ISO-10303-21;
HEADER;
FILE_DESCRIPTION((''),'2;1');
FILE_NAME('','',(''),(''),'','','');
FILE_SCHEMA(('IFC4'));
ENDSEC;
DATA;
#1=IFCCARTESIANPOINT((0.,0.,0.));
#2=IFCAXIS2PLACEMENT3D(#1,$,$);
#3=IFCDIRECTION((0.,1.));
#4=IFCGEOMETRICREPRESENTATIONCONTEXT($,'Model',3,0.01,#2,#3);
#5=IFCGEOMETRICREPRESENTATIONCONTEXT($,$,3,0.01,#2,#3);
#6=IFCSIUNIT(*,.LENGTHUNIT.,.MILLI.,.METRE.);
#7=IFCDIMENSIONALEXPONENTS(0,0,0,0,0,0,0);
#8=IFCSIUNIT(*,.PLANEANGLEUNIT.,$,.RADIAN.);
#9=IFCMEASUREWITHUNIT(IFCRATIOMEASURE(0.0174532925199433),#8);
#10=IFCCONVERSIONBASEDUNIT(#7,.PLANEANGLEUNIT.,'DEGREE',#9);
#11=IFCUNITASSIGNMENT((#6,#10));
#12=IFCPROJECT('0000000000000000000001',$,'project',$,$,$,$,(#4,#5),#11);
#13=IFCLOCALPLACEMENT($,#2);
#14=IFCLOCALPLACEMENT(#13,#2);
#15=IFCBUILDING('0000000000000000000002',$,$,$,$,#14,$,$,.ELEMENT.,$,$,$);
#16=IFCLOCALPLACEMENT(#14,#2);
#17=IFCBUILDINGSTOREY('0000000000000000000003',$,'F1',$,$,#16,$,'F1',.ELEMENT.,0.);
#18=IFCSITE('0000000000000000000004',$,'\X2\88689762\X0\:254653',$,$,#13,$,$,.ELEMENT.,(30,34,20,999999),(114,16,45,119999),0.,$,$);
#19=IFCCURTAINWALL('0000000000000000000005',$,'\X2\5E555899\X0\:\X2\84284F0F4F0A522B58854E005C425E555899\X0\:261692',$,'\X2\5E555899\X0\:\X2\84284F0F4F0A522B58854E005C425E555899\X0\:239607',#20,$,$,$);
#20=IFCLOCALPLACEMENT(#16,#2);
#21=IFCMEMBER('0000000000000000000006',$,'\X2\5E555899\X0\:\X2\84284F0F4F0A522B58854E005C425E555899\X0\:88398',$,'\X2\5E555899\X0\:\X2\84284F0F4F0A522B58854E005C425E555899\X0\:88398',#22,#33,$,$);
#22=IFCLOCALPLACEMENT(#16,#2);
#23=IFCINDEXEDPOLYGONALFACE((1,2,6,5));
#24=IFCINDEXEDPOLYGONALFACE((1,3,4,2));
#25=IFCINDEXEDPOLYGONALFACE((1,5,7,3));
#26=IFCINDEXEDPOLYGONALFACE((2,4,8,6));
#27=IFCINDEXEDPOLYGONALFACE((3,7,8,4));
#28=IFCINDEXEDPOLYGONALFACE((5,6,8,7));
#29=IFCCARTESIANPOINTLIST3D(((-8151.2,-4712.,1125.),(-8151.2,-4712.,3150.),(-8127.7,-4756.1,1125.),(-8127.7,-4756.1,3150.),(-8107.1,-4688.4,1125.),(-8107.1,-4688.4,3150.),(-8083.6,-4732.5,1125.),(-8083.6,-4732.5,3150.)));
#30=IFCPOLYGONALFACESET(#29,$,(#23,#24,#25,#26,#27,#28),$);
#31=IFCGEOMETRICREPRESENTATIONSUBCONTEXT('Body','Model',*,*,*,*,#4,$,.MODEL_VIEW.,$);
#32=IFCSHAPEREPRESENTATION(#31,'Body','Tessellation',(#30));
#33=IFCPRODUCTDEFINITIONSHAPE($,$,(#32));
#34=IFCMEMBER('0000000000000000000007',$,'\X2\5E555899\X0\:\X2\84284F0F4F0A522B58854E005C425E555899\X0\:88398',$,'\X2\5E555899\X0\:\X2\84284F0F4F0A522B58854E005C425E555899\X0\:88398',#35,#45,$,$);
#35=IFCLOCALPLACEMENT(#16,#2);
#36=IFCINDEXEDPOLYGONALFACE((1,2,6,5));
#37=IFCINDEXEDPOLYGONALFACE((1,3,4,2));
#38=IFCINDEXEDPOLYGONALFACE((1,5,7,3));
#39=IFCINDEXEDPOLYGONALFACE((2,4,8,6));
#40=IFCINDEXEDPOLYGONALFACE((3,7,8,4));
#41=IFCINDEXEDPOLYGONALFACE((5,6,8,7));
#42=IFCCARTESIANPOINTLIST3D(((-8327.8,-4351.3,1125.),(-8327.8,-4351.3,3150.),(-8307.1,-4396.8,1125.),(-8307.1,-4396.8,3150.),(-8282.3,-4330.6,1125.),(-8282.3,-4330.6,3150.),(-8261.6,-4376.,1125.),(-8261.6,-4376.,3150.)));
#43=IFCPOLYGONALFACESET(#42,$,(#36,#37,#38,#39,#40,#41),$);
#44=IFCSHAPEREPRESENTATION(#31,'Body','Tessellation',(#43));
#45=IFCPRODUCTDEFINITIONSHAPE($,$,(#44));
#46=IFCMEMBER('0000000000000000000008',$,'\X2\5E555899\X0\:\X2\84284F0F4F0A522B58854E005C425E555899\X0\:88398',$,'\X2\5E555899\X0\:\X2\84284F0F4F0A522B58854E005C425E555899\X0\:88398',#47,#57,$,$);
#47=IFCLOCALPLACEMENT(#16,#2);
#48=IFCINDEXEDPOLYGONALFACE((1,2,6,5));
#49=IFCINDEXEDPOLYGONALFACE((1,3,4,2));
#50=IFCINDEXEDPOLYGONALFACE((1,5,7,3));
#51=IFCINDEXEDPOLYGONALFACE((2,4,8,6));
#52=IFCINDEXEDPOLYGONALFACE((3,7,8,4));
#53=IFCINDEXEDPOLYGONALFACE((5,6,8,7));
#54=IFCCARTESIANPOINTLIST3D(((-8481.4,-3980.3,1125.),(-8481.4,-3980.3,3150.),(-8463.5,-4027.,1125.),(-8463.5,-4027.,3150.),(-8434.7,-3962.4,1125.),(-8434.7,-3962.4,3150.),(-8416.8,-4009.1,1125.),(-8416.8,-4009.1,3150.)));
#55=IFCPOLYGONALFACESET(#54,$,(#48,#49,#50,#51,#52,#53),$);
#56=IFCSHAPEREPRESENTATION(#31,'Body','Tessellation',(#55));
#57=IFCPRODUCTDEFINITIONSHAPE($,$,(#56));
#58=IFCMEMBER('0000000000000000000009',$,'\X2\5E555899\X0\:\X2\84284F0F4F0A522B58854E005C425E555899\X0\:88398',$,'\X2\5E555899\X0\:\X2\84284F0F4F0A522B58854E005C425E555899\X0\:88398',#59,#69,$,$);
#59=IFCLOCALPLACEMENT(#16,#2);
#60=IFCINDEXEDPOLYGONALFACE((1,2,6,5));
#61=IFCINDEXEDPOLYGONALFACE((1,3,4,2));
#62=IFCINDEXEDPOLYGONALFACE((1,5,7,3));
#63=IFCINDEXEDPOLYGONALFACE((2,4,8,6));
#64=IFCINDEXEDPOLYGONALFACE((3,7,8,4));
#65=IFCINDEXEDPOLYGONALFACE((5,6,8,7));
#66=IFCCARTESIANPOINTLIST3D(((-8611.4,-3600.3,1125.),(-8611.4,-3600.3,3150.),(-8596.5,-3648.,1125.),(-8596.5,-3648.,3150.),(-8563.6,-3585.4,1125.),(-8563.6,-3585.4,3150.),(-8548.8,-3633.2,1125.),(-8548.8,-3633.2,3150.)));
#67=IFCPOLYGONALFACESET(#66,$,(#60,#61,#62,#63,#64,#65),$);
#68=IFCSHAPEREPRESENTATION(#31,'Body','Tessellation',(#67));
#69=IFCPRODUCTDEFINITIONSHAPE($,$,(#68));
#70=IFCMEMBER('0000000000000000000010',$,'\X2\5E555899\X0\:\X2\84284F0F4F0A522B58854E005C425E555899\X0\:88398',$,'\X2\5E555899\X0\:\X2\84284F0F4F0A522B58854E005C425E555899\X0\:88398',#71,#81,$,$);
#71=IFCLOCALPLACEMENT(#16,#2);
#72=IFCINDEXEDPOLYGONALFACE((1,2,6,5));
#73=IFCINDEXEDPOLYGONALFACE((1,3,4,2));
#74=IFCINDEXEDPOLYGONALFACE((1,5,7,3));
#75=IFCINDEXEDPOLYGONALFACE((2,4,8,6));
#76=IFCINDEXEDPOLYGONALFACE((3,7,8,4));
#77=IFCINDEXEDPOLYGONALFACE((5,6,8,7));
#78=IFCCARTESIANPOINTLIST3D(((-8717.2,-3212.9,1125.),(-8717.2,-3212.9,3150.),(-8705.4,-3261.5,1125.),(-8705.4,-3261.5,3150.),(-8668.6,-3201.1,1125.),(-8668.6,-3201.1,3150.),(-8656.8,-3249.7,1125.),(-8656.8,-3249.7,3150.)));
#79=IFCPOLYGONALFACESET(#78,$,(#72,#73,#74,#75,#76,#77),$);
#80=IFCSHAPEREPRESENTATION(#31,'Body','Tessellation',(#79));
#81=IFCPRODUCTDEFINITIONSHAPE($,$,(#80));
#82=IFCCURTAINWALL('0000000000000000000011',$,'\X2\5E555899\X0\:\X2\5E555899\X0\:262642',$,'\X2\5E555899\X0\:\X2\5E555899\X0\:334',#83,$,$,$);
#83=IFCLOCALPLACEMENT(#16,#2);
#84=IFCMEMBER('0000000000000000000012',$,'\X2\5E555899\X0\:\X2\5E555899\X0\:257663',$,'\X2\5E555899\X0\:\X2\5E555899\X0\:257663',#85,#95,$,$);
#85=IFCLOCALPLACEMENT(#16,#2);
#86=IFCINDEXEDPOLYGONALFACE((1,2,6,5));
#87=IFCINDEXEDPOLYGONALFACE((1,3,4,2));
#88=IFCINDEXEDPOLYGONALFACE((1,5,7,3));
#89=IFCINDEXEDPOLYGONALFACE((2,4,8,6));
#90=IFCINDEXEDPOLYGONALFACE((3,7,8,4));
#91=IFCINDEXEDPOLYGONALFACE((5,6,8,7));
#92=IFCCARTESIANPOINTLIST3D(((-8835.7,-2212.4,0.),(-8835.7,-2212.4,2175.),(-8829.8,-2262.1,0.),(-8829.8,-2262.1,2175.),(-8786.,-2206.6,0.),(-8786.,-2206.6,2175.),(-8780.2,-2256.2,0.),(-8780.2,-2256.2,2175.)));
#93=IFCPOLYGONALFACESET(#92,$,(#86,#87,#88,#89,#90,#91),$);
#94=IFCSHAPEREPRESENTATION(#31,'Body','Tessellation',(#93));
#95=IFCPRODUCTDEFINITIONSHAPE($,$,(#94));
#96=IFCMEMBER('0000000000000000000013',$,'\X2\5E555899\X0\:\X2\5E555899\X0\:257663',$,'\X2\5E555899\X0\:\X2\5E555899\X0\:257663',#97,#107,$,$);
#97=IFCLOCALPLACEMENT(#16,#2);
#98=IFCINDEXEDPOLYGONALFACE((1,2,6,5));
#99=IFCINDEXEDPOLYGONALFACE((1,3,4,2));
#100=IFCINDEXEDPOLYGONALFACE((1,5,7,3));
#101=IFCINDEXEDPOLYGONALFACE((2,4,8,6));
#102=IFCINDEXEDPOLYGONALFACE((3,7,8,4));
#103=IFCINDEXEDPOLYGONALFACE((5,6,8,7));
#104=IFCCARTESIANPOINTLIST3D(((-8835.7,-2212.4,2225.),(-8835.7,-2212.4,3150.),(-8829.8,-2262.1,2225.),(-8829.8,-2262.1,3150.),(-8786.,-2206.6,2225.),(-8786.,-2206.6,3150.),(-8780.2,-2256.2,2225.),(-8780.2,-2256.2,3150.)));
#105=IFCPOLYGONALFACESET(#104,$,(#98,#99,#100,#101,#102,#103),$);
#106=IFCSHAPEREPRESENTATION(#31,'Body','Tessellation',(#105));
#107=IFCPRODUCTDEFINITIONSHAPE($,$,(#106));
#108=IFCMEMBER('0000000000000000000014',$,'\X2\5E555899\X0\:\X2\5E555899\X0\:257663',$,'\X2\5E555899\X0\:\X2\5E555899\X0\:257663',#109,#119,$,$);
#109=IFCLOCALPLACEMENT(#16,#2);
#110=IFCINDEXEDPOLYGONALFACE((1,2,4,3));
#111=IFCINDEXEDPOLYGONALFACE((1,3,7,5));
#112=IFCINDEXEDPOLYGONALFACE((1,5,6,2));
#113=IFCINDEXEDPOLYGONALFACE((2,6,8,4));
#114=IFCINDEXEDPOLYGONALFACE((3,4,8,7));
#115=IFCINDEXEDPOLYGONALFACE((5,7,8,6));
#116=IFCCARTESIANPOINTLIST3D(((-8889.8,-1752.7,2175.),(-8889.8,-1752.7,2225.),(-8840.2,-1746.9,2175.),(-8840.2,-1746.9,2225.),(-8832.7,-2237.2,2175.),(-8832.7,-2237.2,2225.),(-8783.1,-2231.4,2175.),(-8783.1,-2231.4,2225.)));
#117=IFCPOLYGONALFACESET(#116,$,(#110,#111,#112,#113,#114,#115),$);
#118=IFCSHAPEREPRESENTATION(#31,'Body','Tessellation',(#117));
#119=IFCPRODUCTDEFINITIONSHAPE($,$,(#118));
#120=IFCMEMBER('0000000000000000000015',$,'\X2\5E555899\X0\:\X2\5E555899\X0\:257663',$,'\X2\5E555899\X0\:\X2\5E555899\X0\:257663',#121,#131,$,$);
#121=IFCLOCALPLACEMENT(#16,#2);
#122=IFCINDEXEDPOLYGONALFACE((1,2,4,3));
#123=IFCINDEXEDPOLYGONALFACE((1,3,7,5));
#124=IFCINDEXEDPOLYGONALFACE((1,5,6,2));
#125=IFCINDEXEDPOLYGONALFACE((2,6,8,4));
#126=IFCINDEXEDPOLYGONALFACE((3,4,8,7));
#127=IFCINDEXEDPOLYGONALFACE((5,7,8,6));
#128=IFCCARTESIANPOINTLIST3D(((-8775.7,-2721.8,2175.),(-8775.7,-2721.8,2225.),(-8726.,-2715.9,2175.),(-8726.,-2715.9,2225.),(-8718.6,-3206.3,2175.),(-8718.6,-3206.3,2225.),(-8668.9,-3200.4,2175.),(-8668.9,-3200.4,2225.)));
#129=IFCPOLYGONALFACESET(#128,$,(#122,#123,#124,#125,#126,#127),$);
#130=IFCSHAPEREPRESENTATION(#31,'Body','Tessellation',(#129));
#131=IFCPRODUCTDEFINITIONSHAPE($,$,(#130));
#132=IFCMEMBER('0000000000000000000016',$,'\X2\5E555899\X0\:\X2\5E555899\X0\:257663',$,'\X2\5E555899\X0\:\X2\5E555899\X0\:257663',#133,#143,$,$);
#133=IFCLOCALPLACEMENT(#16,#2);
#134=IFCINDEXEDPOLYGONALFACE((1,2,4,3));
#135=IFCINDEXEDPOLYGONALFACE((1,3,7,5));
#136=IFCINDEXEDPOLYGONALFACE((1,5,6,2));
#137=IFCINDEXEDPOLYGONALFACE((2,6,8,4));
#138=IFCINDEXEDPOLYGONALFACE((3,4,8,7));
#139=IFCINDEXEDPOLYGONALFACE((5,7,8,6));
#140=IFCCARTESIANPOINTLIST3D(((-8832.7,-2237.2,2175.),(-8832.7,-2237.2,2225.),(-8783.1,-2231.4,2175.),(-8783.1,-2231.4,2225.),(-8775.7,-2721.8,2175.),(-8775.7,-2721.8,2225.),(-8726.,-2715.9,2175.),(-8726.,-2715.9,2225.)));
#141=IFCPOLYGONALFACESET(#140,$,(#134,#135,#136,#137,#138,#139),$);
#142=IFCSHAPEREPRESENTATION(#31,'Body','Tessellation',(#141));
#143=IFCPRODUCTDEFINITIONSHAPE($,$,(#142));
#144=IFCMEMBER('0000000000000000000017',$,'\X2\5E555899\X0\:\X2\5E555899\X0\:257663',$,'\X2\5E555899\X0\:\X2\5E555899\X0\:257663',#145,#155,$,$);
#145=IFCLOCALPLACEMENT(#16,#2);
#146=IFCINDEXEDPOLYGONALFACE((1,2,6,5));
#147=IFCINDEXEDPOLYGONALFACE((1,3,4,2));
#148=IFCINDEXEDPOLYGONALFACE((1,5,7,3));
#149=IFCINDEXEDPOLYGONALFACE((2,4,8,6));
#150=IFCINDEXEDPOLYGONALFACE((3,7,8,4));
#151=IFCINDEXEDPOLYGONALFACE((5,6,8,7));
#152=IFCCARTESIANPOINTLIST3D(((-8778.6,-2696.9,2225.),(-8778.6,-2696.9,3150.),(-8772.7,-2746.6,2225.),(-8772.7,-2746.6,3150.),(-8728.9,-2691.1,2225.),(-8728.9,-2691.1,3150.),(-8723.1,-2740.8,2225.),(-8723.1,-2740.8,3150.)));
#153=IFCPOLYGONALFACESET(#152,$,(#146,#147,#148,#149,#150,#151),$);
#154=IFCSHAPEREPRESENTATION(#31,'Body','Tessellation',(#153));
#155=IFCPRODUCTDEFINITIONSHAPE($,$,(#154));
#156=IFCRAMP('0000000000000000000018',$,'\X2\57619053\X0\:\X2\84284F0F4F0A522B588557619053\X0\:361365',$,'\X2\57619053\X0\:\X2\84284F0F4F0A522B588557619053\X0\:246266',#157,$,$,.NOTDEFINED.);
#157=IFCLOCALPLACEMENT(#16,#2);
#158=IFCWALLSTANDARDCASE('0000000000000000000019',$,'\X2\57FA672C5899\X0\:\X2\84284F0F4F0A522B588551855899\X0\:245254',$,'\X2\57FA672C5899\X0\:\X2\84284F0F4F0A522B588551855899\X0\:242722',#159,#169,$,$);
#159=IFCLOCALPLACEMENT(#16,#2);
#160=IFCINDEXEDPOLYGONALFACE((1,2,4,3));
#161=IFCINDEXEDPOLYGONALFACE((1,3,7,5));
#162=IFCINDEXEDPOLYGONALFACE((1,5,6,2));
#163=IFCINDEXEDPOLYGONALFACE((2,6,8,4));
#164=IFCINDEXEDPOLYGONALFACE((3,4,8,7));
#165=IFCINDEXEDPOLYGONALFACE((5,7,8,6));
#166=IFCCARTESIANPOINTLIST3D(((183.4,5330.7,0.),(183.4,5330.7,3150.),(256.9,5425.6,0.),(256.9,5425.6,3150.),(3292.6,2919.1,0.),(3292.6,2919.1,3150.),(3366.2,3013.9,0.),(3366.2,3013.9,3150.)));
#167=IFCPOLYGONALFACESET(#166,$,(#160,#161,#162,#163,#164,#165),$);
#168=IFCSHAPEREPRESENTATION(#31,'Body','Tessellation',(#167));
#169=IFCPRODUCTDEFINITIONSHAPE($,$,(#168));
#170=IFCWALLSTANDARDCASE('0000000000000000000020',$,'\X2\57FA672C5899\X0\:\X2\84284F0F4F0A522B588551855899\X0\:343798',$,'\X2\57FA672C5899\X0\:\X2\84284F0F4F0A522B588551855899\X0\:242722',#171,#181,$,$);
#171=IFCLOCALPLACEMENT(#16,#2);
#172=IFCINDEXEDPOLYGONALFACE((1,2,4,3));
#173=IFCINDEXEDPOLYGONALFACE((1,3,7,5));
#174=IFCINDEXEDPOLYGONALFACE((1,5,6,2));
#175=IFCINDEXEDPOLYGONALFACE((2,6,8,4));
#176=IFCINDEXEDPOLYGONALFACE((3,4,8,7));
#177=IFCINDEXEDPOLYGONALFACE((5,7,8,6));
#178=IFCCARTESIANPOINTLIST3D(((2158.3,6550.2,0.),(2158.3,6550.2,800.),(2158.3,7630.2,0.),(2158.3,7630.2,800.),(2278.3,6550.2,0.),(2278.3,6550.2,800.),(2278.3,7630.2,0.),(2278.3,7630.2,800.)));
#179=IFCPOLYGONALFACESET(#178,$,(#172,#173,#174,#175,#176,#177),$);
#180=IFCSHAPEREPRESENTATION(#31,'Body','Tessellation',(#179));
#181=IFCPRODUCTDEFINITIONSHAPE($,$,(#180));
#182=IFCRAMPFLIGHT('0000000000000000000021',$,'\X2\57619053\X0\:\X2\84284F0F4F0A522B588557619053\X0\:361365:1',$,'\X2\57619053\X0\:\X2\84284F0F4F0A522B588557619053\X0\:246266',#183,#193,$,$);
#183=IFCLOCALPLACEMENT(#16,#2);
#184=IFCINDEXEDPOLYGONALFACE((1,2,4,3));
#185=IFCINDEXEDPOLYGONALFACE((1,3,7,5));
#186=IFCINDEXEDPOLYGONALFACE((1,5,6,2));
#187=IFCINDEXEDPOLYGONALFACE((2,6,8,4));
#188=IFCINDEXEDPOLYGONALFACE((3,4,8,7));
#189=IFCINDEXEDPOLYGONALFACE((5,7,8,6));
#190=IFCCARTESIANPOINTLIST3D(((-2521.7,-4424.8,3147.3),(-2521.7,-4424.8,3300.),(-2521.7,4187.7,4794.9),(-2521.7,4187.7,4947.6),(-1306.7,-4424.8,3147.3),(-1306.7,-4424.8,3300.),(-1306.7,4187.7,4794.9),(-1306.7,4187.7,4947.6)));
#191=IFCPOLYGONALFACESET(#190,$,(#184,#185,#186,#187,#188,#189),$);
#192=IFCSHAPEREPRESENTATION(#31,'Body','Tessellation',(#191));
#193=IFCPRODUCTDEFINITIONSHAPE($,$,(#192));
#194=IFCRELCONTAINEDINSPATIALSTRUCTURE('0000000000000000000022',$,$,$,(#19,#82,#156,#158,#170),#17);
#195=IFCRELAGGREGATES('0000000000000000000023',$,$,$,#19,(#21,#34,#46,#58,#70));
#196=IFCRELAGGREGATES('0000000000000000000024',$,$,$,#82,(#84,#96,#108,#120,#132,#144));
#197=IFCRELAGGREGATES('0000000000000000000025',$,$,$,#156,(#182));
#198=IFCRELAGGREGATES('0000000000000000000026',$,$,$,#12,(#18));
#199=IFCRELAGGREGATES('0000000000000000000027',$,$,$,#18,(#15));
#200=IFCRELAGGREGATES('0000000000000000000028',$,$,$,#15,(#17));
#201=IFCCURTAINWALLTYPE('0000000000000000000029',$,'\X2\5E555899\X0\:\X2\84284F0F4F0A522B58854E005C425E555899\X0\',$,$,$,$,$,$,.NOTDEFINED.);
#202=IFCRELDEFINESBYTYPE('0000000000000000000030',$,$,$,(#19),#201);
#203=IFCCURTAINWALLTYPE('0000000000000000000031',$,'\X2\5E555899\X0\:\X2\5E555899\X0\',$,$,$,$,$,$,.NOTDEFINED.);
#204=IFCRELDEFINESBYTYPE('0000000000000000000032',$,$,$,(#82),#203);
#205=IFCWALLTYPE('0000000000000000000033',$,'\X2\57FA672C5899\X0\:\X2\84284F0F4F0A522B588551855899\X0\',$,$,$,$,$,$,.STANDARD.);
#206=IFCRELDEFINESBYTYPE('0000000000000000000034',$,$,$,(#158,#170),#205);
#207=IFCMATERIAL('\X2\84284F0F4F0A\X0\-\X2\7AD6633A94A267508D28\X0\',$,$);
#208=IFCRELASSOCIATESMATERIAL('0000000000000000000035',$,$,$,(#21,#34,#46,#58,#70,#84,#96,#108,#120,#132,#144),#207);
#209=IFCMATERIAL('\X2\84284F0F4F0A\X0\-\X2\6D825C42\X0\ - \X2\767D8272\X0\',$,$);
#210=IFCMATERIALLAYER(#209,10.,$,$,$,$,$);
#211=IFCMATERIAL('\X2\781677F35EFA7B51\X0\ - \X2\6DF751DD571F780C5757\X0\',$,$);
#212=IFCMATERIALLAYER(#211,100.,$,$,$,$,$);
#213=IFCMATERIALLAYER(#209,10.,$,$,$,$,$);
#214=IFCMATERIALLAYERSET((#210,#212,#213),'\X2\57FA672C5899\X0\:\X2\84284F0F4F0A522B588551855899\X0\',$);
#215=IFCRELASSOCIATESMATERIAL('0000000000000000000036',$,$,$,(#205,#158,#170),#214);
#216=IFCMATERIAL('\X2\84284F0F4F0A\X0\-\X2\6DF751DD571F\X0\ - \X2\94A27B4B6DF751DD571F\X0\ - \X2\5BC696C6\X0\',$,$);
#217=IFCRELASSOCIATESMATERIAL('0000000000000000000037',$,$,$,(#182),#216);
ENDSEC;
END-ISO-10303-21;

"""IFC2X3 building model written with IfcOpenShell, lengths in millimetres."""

from ifc_helpers import new_model, entity, si_unit, converted_unit, direction, frame, frame_2d, origin, origin_2d_with_axis, place, context, subcontext, project, spatial, polyline, rectangle, outline, extrude, clip, bounded_halfspace, material, layer, layer_set, layer_usage, type_object, element, aggregate, save


model = new_model("IFC2X3")

# Units and contexts
model_context = context("Model", 3, precision=0.01, world=origin(), true_north=direction((0.0, 1.0)))
context_of_model = context(None, 3, precision=0.01, world=origin(), true_north=direction((0.0, 1.0)))
body_context = subcontext(model_context, "Body", "Model", "MODEL_VIEW")
ifc_project = project(units=[si_unit("LENGTHUNIT", "METRE", prefix="MILLI"), converted_unit("PLANEANGLEUNIT", "DEGREE", entity("IfcRatioMeasure", 0.0174532925199433), si_unit("PLANEANGLEUNIT", "RADIAN"), dimensions=[0, 0, 0, 0, 0, 0, 0])], contexts=[model_context, context_of_model])

# Site, building, storey
site_placement = place(None, origin())
site = spatial("IfcSite", under=ifc_project, at=site_placement, Name="表面:254653", CompositionType="ELEMENT", RefLatitude=(30, 34, 20, 999999), RefLongitude=(114, 16, 45, 119999), RefElevation=0.0)
building_placement = place(site_placement, origin())
building = spatial("IfcBuilding", under=site, at=building_placement, CompositionType="ELEMENT")
storey_placement = place(building_placement, origin())
storey = spatial("IfcBuildingStorey", under=building, at=storey_placement, Name="F1", LongName="F1", CompositionType="ELEMENT", Elevation=0.0)

# Curtain walls, members
curtain_wall_type_1 = type_object("IfcCurtainWallType", Name="幕墙:萨伏伊别墅一层幕墙", PredefinedType="NOTDEFINED")
curtain_wall_1_placement = place(storey_placement, origin())
curtain_wall_1 = element("IfcCurtainWall", 1, at=curtain_wall_1_placement, inside=storey, type_object=curtain_wall_type_1, Name="幕墙:萨伏伊别墅一层幕墙:261692", ObjectType="幕墙:萨伏伊别墅一层幕墙:239607")
ifc_material_1 = material(Name="萨伏伊-竖挺钢材质")
member_1_placement = place(curtain_wall_1_placement, origin())
member_1 = element("IfcMember", 2, at=member_1_placement, material=ifc_material_1, Name="幕墙:萨伏伊别墅一层幕墙:88398", ObjectType="幕墙:萨伏伊别墅一层幕墙:88398", context=body_context, shape_type="SweptSolid", body=[
    extrude(rectangle(XDim=50.0, YDim=50.0, at=frame_2d((0.0, 0.0), x_axis=(1.0, 0.0))), frame((-8117.4, -4722.2, 1125.0), z_axis=(0.0, 0.0, 1.0), x_axis=(-0.471192, 0.882031, 0.0)), (0.0, 0.0, 1.0), 2025.0),
])
member_2_placement = place(curtain_wall_1_placement, origin())
member_2 = element("IfcMember", 3, at=member_2_placement, material=ifc_material_1, Name="幕墙:萨伏伊别墅一层幕墙:88398", ObjectType="幕墙:萨伏伊别墅一层幕墙:88398", context=body_context, shape_type="SweptSolid", body=[
    extrude(rectangle(XDim=50.0, YDim=50.0, at=frame_2d((0.0, 0.0), x_axis=(1.0, 0.0))), frame((-8294.7, -4363.7, 1125.0), z_axis=(0.0, 0.0, 1.0), x_axis=(-0.414863, 0.909884, 0.0)), (0.0, 0.0, 1.0), 2025.0),
])
member_3_placement = place(curtain_wall_1_placement, origin())
member_3 = element("IfcMember", 4, at=member_3_placement, material=ifc_material_1, Name="幕墙:萨伏伊别墅一层幕墙:88398", ObjectType="幕墙:萨伏伊别墅一层幕墙:88398", context=body_context, shape_type="SweptSolid", body=[
    extrude(rectangle(XDim=50.0, YDim=50.0, at=frame_2d((0.0, 0.0), x_axis=(1.0, 0.0))), frame((-8449.1, -3994.7, 1125.0), z_axis=(0.0, 0.0, 1.0), x_axis=(-0.356897, 0.934144, 0.0)), (0.0, 0.0, 1.0), 2025.0),
])
member_4_placement = place(curtain_wall_1_placement, origin())
member_4 = element("IfcMember", 5, at=member_4_placement, material=ifc_material_1, Name="幕墙:萨伏伊别墅一层幕墙:88398", ObjectType="幕墙:萨伏伊别墅一层幕墙:88398", context=body_context, shape_type="SweptSolid", body=[
    extrude(rectangle(XDim=50.0, YDim=50.0, at=frame_2d((0.0, 0.0), x_axis=(1.0, 0.0))), frame((-8580.1, -3616.7, 1125.0), z_axis=(0.0, 0.0, 1.0), x_axis=(-0.297522, 0.954715, 0.0)), (0.0, 0.0, 1.0), 2025.0),
])
member_5_placement = place(curtain_wall_1_placement, origin())
member_5 = element("IfcMember", 6, at=member_5_placement, material=ifc_material_1, Name="幕墙:萨伏伊别墅一层幕墙:88398", ObjectType="幕墙:萨伏伊别墅一层幕墙:88398", context=body_context, shape_type="SweptSolid", body=[
    extrude(rectangle(XDim=50.0, YDim=50.0, at=frame_2d((0.0, 0.0), x_axis=(1.0, 0.0))), frame((-8687.0, -3231.3, 1125.0), z_axis=(0.0, 0.0, 1.0), x_axis=(-0.236972, 0.971517, 0.0)), (0.0, 0.0, 1.0), 2025.0),
])
aggregate(curtain_wall_1, [member_1, member_2, member_3, member_4, member_5])
curtain_wall_type_2 = type_object("IfcCurtainWallType", Name="幕墙:幕墙", PredefinedType="NOTDEFINED")
curtain_wall_2_placement = place(storey_placement, origin())
curtain_wall_2 = element("IfcCurtainWall", 7, at=curtain_wall_2_placement, inside=storey, type_object=curtain_wall_type_2, Name="幕墙:幕墙:262642", ObjectType="幕墙:幕墙:334")
member_6_placement = place(curtain_wall_2_placement, origin())
member_6 = element("IfcMember", 8, at=member_6_placement, material=ifc_material_1, Name="幕墙:幕墙:257663", ObjectType="幕墙:幕墙:257663", context=body_context, shape_type="SweptSolid", body=[
    extrude(rectangle(XDim=50.0, YDim=50.0, at=frame_2d((0.0, 0.0), x_axis=(1.0, 0.0))), frame((-8807.9, -2234.3, 0.0), z_axis=(0.0, 0.0, 1.0), x_axis=(-0.117005, 0.993131, 0.0)), (0.0, 0.0, 1.0), 2175.0),
])
member_7_placement = place(curtain_wall_2_placement, origin())
member_7 = element("IfcMember", 9, at=member_7_placement, material=ifc_material_1, Name="幕墙:幕墙:257663", ObjectType="幕墙:幕墙:257663", context=body_context, shape_type="SweptSolid", body=[
    extrude(rectangle(XDim=50.0, YDim=50.0, at=frame_2d((0.0, 0.0), x_axis=(1.0, 0.0))), frame((-8807.9, -2234.3, 2225.0), z_axis=(0.0, 0.0, 1.0), x_axis=(-0.117005, 0.993131, 0.0)), (0.0, 0.0, 1.0), 925.0),
])
member_8_placement = place(curtain_wall_2_placement, origin())
member_8 = element("IfcMember", 10, at=member_8_placement, material=ifc_material_1, Name="幕墙:幕墙:257663", ObjectType="幕墙:幕墙:257663", context=body_context, shape_type="SweptSolid", body=[
    extrude(rectangle(XDim=50.0, YDim=50.0, at=origin_2d_with_axis()), frame((-8865.0, -1749.8, 2200.0), z_axis=(0.117005, -0.993131, 0.0), x_axis=(0.0, 0.0, -1.0)), (0.0, 0.0, 1.0), 487.9),
])
member_9_placement = place(curtain_wall_2_placement, origin())
member_9 = element("IfcMember", 11, at=member_9_placement, material=ifc_material_1, Name="幕墙:幕墙:257663", ObjectType="幕墙:幕墙:257663", context=body_context, shape_type="SweptSolid", body=[
    extrude(rectangle(XDim=50.0, YDim=50.0, at=origin_2d_with_axis()), frame((-8750.8, -2718.8, 2200.0), z_axis=(0.117005, -0.993131, 0.0), x_axis=(0.0, 0.0, -1.0)), (0.0, 0.0, 1.0), 487.9),
])
member_10_placement = place(curtain_wall_2_placement, origin())
member_10 = element("IfcMember", 12, at=member_10_placement, material=ifc_material_1, Name="幕墙:幕墙:257663", ObjectType="幕墙:幕墙:257663", context=body_context, shape_type="SweptSolid", body=[
    extrude(rectangle(XDim=50.0, YDim=50.0, at=origin_2d_with_axis()), frame((-8807.9, -2234.3, 2200.0), z_axis=(0.117005, -0.993131, 0.0), x_axis=(0.0, 0.0, -1.0)), (0.0, 0.0, 1.0), 487.9),
])
member_11_placement = place(curtain_wall_2_placement, origin())
member_11 = element("IfcMember", 13, at=member_11_placement, material=ifc_material_1, Name="幕墙:幕墙:257663", ObjectType="幕墙:幕墙:257663", context=body_context, shape_type="SweptSolid", body=[
    extrude(rectangle(XDim=50.0, YDim=50.0, at=origin_2d_with_axis()), frame((-8750.8, -2718.8, 2225.0), z_axis=(0.0, 0.0, 1.0), x_axis=(-0.117005, 0.993131, 0.0)), (0.0, 0.0, 1.0), 925.0),
])
aggregate(curtain_wall_2, [member_6, member_7, member_8, member_9, member_10, member_11])

# Shared definitions
ifc_material_2 = material(Name="萨伏伊-涂层 - 白色")

# Ramp
ramp_placement = place(storey_placement, origin())
ramp = element("IfcRamp", 14, at=ramp_placement, inside=storey, Name="坡道:萨伏伊别墅坡道:361365", ObjectType="坡道:萨伏伊别墅坡道:246266", ShapeType="NOTDEFINED")
ifc_material_3 = material(Name="萨伏伊-混凝土 - 钢筋混凝土 - 密集")

# Walls
ifc_layer_1 = layer(ifc_material_2, 10.0)
ifc_material_4 = material(Name="砖石建筑 - 混凝土砌块")
ifc_layer_2 = layer(ifc_material_4, 100.0)
ifc_layer_3 = layer(ifc_material_2, 10.0)
ifc_layer_set_1 = layer_set([ifc_layer_1, ifc_layer_2, ifc_layer_3], Name="基本墙:萨伏伊别墅内墙")
ifc_layer_usage_1 = layer_usage(ifc_layer_set_1, "AXIS2", "NEGATIVE", 60.0)
wall_type = type_object("IfcWallType", Name="基本墙:萨伏伊别墅内墙", PredefinedType="STANDARD", material=ifc_layer_set_1)
wall_1_placement = place(storey_placement, frame((220.2, 5378.1, 0.0), z_axis=(0.0, 0.0, 1.0), x_axis=(0.790172, -0.612885, 0.0)))
element("IfcWallStandardCase", 15, at=wall_1_placement, inside=storey, type_object=wall_type, material=ifc_layer_usage_1, Name="基本墙:萨伏伊别墅内墙:245254", ObjectType="基本墙:萨伏伊别墅内墙:242722", context=body_context, shape_type="Clipping", body=[
    clip(extrude(rectangle(XDim=3934.9, YDim=120.0, at=frame_2d((1967.4, 0.0), x_axis=(-1.0, 0.0))), origin(), (0.0, 0.0, 1.0), 3150.0), bounded_halfspace(frame((0.0, -60.0, 3150.0), z_axis=(0.0, 0.0, -1.0), x_axis=(0.612885, -0.790172, 0.0)), True, frame((0.0, -60.0, 3150.0)), polyline([(0.0, 0.0), (3934.9, 0.0), (3934.9, 120.0), (0.0, 120.0), (0.0, 0.0)]))),
])
ifc_layer_usage_2 = layer_usage(ifc_layer_set_1, "AXIS2", "NEGATIVE", 60.0)
wall_2_placement = place(storey_placement, frame((2218.3, 7630.2, 0.0), z_axis=(0.0, 0.0, 1.0), x_axis=(0.0, -1.0, 0.0)))
element("IfcWallStandardCase", 16, at=wall_2_placement, inside=storey, type_object=wall_type, material=ifc_layer_usage_2, Name="基本墙:萨伏伊别墅内墙:343798", ObjectType="基本墙:萨伏伊别墅内墙:242722", context=body_context, shape_type="SweptSolid", body=[
    extrude(rectangle(XDim=1080.0, YDim=120.0, at=frame_2d((540.0, 0.0), x_axis=(-1.0, 0.0))), origin(), (0.0, 0.0, 1.0), 800.0),
])

# Ramp flight
ramp_flight_1_placement = place(ramp_placement, origin())
ramp_flight_1 = element("IfcRampFlight", 17, at=ramp_flight_1_placement, material=ifc_material_3, Name="坡道:萨伏伊别墅坡道:361365:1", ObjectType="坡道:萨伏伊别墅坡道:246266", context=body_context, shape_type="SweptSolid", body=[
    extrude(outline(polyline([(747.4, -4306.2), (900.2, -4306.2), (-747.4, 4306.2), (-900.2, 4306.2), (747.4, -4306.2)])), frame((-2521.7, -118.6, 4047.4), z_axis=(1.0, 0.0, 0.0), x_axis=(0.0, 0.0, -1.0)), (0.0, 0.0, 1.0), 1215.0),
])
aggregate(ramp, [ramp_flight_1])

save(model, "model.ifc")
